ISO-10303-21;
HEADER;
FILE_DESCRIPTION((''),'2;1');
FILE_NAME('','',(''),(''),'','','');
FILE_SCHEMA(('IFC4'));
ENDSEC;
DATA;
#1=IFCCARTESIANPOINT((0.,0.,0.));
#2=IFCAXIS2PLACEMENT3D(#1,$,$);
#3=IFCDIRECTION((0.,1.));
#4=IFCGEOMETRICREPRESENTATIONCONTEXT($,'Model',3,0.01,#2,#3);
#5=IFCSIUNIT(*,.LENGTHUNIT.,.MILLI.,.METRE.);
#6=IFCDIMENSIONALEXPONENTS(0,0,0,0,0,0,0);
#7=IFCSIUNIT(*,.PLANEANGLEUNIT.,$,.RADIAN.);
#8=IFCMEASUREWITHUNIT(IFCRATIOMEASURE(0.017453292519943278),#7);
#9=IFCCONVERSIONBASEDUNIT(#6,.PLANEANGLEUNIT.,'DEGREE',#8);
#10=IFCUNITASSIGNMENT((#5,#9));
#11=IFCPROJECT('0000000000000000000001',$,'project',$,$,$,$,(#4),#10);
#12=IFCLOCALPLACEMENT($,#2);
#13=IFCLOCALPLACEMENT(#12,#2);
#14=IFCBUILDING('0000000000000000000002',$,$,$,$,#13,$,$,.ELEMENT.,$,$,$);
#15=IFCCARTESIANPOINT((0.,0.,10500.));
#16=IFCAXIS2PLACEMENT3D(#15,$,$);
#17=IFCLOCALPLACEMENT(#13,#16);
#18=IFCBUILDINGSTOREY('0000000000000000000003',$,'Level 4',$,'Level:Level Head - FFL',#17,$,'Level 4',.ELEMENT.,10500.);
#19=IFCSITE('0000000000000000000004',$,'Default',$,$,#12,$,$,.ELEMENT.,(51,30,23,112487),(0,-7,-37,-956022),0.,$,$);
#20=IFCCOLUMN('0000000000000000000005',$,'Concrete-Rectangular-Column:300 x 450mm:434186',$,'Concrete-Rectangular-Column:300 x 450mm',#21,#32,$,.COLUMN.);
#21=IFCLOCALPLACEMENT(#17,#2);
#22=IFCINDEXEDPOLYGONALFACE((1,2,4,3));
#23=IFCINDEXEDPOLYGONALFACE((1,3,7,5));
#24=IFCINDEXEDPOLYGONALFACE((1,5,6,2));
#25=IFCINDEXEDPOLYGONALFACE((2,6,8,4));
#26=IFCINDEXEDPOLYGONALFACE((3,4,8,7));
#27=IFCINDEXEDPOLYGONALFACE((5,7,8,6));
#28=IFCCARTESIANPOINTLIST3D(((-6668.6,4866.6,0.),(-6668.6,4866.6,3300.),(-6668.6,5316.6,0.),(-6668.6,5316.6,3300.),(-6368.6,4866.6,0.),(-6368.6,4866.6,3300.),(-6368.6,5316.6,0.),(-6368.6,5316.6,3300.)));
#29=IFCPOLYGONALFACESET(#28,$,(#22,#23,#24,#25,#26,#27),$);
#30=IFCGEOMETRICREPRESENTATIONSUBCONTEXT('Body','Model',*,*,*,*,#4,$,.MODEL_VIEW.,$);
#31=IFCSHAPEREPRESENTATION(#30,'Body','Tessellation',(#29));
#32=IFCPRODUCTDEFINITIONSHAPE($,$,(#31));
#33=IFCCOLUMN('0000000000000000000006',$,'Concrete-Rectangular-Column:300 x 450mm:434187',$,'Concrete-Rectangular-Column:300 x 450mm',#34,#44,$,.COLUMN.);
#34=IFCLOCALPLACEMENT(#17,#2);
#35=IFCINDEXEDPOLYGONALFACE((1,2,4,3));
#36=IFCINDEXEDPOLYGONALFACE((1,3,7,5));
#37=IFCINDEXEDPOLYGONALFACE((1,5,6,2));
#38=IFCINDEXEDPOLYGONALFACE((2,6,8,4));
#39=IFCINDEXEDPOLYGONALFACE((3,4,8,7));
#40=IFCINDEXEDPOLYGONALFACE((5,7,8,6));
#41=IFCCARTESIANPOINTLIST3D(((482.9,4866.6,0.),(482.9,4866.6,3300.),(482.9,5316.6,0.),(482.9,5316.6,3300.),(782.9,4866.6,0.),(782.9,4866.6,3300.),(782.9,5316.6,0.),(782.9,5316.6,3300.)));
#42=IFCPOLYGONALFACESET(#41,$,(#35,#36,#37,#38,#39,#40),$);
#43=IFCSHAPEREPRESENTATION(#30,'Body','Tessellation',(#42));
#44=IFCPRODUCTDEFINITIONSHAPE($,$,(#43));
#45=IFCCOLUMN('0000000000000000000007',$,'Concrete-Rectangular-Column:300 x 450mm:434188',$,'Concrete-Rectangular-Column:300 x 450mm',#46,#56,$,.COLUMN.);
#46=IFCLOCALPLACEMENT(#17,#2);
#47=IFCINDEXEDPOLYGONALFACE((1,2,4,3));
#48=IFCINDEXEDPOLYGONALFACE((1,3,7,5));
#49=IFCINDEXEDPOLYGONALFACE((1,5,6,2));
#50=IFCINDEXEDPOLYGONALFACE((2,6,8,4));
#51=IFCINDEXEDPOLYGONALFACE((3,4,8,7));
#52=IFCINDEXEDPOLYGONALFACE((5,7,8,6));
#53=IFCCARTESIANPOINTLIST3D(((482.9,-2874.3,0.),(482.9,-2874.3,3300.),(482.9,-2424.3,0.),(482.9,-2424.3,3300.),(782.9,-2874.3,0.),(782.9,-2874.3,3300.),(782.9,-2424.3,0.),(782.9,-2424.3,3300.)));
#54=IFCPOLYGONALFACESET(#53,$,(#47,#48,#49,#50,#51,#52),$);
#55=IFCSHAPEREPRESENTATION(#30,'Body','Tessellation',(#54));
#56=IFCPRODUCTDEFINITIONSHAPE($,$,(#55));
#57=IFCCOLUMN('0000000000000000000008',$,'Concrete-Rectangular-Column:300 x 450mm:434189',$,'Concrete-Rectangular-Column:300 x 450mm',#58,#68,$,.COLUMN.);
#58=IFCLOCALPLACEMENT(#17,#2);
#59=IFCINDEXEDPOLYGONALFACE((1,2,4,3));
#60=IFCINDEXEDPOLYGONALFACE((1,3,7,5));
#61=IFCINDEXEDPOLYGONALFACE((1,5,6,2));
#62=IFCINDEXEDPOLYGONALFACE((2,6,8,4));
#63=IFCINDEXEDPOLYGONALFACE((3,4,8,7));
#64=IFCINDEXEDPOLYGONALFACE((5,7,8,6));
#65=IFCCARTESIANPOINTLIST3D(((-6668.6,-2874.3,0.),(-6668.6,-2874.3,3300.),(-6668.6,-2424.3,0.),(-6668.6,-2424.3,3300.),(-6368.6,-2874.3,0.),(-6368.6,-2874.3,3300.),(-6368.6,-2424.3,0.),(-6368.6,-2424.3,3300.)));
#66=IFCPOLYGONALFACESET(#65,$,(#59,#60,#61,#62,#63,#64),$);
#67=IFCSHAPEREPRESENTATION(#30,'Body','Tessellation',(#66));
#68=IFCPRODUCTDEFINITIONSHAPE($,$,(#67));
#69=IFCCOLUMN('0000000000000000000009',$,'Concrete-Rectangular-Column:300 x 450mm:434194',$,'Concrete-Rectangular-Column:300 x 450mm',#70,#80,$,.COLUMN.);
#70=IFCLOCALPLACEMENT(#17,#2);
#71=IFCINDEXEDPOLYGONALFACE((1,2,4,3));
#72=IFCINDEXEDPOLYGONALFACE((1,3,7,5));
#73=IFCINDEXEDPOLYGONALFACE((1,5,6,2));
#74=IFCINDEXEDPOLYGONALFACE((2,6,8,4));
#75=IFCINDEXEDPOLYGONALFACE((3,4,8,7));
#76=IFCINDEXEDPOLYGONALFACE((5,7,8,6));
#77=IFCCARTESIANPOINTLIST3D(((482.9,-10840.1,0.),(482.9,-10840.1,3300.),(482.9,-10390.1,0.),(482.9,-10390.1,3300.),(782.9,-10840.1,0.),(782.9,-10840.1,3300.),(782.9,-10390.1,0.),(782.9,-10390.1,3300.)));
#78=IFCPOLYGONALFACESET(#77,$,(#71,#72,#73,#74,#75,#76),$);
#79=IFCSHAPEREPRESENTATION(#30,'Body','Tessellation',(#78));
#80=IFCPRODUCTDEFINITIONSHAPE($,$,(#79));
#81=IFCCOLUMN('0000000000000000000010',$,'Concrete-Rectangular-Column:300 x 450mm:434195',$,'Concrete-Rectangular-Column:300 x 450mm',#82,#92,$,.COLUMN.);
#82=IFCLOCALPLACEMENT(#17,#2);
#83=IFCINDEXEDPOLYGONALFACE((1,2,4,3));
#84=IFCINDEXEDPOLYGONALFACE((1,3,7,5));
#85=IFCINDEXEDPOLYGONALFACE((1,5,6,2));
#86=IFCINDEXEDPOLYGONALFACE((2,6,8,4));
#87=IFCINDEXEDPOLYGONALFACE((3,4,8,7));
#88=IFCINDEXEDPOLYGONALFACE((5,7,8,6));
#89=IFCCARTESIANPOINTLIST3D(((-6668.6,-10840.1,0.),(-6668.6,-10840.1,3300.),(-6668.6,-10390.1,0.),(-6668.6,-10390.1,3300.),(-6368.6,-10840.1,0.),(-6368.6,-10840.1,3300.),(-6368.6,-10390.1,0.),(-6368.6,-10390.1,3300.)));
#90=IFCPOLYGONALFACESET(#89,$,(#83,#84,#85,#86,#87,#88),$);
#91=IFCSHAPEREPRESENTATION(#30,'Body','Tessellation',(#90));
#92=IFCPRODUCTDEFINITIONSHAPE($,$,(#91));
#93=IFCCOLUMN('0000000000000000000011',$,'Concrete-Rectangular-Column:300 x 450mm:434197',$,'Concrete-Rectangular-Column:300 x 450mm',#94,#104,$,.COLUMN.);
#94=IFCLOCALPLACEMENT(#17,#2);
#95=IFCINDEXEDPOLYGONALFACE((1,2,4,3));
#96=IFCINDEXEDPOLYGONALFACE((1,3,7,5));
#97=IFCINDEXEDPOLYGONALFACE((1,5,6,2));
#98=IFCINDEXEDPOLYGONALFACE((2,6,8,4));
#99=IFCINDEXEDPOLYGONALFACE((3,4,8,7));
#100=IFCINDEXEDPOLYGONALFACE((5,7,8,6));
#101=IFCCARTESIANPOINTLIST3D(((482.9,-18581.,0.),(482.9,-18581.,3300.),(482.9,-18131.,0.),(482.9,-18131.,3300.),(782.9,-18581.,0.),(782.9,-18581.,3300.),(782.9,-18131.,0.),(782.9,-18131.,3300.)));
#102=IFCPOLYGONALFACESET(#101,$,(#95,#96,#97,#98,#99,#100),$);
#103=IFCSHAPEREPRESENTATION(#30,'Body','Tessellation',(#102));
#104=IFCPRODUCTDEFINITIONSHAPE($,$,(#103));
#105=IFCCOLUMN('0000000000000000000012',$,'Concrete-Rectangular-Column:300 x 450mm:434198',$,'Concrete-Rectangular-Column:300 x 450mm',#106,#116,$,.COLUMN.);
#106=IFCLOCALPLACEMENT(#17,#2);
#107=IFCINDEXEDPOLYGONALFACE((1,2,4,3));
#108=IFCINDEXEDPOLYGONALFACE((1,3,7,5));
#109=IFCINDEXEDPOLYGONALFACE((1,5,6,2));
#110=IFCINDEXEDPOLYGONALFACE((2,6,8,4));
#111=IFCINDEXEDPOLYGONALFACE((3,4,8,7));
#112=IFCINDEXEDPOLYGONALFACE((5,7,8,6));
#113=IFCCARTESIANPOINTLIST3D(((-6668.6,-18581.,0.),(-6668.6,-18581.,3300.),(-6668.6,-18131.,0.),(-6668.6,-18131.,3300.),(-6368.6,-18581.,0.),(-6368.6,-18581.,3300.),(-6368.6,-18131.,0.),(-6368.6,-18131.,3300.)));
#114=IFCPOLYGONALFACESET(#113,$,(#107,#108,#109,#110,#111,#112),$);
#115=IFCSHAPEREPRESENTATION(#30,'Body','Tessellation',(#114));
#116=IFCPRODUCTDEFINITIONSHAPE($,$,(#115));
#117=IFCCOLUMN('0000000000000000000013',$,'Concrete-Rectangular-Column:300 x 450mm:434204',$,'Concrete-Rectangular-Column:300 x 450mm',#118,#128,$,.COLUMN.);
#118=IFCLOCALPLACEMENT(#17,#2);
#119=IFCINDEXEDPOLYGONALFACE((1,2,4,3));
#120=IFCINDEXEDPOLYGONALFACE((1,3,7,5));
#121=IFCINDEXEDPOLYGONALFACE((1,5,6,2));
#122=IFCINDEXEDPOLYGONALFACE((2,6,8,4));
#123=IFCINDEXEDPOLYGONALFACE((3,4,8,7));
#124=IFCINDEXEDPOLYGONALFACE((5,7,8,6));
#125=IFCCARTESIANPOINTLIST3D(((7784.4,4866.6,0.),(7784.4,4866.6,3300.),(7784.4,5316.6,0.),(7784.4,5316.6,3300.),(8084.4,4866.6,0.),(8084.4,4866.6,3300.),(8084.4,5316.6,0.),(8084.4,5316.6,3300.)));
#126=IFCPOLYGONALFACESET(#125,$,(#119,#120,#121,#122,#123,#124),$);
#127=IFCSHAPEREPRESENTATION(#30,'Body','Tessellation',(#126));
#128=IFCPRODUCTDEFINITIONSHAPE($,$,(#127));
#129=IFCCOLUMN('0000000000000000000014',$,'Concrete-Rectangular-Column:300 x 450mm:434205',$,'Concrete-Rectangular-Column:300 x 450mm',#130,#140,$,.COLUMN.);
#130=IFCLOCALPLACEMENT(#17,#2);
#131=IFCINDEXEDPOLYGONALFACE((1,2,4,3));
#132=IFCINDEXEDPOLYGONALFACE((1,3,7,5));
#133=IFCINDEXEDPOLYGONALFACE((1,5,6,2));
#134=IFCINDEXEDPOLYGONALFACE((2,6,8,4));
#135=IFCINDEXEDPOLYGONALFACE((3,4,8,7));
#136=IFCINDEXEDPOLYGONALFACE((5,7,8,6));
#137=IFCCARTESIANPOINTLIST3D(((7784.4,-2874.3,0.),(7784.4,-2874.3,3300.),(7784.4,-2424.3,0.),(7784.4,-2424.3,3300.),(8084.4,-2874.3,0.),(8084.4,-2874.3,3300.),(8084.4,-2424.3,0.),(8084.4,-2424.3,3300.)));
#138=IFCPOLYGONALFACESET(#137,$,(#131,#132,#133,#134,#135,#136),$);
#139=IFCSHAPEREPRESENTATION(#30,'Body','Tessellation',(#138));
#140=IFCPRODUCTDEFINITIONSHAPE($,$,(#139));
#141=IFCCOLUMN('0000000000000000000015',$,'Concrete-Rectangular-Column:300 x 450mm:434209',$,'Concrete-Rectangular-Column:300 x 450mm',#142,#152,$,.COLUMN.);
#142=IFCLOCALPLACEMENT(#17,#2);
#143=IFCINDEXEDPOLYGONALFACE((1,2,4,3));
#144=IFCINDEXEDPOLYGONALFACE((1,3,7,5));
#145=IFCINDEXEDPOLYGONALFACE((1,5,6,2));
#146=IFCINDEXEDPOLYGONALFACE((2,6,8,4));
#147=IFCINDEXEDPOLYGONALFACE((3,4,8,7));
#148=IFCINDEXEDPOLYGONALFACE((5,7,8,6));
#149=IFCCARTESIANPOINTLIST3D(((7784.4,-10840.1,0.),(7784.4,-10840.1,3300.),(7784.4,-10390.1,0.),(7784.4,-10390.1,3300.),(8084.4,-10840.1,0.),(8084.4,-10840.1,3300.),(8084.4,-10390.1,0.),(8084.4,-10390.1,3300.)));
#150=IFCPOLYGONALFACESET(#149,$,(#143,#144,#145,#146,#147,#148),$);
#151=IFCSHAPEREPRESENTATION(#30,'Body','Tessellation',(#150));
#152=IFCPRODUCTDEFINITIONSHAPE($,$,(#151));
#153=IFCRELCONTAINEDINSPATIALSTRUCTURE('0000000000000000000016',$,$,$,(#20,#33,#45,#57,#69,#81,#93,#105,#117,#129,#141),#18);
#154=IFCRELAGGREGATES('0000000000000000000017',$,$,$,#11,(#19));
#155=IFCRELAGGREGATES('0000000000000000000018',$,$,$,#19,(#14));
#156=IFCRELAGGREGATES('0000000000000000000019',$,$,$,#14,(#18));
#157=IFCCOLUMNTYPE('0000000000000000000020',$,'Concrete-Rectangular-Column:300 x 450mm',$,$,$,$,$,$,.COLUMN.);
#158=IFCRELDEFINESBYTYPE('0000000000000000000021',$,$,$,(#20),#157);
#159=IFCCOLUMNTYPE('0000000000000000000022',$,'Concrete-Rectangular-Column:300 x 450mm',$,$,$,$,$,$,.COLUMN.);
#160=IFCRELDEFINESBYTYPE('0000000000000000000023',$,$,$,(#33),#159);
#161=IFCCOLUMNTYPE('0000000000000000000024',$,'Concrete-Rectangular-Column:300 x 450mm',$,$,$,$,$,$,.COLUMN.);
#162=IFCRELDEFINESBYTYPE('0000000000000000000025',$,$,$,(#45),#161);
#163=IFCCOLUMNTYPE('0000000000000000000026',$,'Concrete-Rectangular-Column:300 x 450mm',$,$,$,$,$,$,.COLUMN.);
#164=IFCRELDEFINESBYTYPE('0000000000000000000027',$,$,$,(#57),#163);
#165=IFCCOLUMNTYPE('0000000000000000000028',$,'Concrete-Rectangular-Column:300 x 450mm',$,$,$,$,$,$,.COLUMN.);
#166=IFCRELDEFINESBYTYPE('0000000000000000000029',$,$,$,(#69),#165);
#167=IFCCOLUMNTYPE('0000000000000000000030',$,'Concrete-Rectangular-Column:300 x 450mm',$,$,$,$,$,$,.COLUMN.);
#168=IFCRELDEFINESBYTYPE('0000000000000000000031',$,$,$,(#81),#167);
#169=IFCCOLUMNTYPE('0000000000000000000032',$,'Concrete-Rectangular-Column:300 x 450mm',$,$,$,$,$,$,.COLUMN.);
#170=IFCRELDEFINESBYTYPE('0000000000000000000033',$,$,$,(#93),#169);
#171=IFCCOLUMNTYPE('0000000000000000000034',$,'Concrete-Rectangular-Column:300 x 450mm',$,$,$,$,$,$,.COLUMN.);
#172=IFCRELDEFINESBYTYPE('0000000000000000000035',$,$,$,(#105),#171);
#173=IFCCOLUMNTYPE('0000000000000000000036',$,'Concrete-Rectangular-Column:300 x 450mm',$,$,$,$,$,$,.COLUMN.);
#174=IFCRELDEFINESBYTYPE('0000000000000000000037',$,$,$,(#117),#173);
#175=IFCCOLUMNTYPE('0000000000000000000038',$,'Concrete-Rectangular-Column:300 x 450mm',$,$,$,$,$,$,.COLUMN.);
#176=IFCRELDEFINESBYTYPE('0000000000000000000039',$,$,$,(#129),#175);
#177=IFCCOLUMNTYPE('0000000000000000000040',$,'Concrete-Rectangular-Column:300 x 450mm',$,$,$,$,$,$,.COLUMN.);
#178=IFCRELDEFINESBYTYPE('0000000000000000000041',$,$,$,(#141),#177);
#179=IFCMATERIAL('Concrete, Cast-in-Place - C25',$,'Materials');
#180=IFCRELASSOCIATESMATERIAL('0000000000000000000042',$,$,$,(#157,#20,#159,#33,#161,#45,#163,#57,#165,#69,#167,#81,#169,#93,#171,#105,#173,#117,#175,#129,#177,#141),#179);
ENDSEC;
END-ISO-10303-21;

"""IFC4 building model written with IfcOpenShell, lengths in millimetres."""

from ifc_helpers import new_model, entity, si_unit, converted_unit, direction, frame, origin, place, context, subcontext, project, spatial, indexed_curve, outline, extrude, source, transform, mapped, material, type_object, type_shapes, element, save


model = new_model("IFC4")

# Units and contexts
model_context = context("Model", 3, precision=0.01, world=origin(), true_north=direction((0.0, 1.0)))
body_context = subcontext(model_context, "Body", "Model", "MODEL_VIEW")
ifc_project = project(units=[si_unit("LENGTHUNIT", "METRE", prefix="MILLI"), converted_unit("PLANEANGLEUNIT", "DEGREE", entity("IfcRatioMeasure", 0.017453292519943278), si_unit("PLANEANGLEUNIT", "RADIAN"), dimensions=[0, 0, 0, 0, 0, 0, 0])], contexts=[model_context])

# Site, building, storey
site_placement = place(None, origin())
site = spatial("IfcSite", under=ifc_project, at=site_placement, Name="Default", CompositionType="ELEMENT", RefLatitude=(51, 30, 23, 112487), RefLongitude=(0, -7, -37, -956022), RefElevation=0.0)
building_placement = place(site_placement, origin())
building = spatial("IfcBuilding", under=site, at=building_placement, CompositionType="ELEMENT")
storey_placement = place(building_placement, frame((0.0, 0.0, 10500.0)))
storey = spatial("IfcBuildingStorey", under=building, at=storey_placement, Name="Level 4", ObjectType="Level:Level Head - FFL", LongName="Level 4", CompositionType="ELEMENT", Elevation=10500.0)

# Columns
ifc_material = material(Name="Concrete, Cast-in-Place - C25", Category="Materials")
column_type_1 = type_object("IfcColumnType", Name="Concrete-Rectangular-Column:300 x 450mm", PredefinedType="COLUMN", material=ifc_material)
shared_shape_1 = source(origin(), body_context, "Body", "SweptSolid", [
    extrude(outline(indexed_curve([(-225.0, -150.0), (225.0, -150.0), (225.0, 150.0), (-225.0, 150.0), (-225.0, -150.0)], self_intersect=False)), frame((-6518.6, 5091.6, 10500.0), z_axis=(0.0, 0.0, 1.0), x_axis=(0.0, -1.0, 0.0)), (0.0, 0.0, 1.0), 3300.0),
])
type_shapes(column_type_1, [shared_shape_1])
column_1_placement = place(storey_placement, frame((0.0, 0.0, -10500.0)))
element("IfcColumn", 1, at=column_1_placement, inside=storey, type_object=column_type_1, material=ifc_material, Name="Concrete-Rectangular-Column:300 x 450mm:434186", ObjectType="Concrete-Rectangular-Column:300 x 450mm", PredefinedType="COLUMN", context=body_context, shape_type="MappedRepresentation", body=[
    mapped(shared_shape_1, transform((0.0, 0.0, 0.0), scale=1.0)),
])
column_type_2 = type_object("IfcColumnType", Name="Concrete-Rectangular-Column:300 x 450mm", PredefinedType="COLUMN", material=ifc_material)
shared_shape_2 = source(origin(), body_context, "Body", "SweptSolid", [
    extrude(outline(indexed_curve([(-225.0, -150.0), (225.0, -150.0), (225.0, 150.0), (-225.0, 150.0), (-225.0, -150.0)], self_intersect=False)), frame((632.9, 5091.6, 10500.0), z_axis=(0.0, 0.0, 1.0), x_axis=(0.0, -1.0, 0.0)), (0.0, 0.0, 1.0), 3300.0),
])
type_shapes(column_type_2, [shared_shape_2])
column_2_placement = place(storey_placement, frame((0.0, 0.0, -10500.0)))
element("IfcColumn", 2, at=column_2_placement, inside=storey, type_object=column_type_2, material=ifc_material, Name="Concrete-Rectangular-Column:300 x 450mm:434187", ObjectType="Concrete-Rectangular-Column:300 x 450mm", PredefinedType="COLUMN", context=body_context, shape_type="MappedRepresentation", body=[
    mapped(shared_shape_2, transform((0.0, 0.0, 0.0), scale=1.0)),
])
column_type_3 = type_object("IfcColumnType", Name="Concrete-Rectangular-Column:300 x 450mm", PredefinedType="COLUMN", material=ifc_material)
shared_shape_3 = source(origin(), body_context, "Body", "SweptSolid", [
    extrude(outline(indexed_curve([(-225.0, -150.0), (225.0, -150.0), (225.0, 150.0), (-225.0, 150.0), (-225.0, -150.0)], self_intersect=False)), frame((632.9, -2649.3, 10500.0), z_axis=(0.0, 0.0, 1.0), x_axis=(0.0, -1.0, 0.0)), (0.0, 0.0, 1.0), 3300.0),
])
type_shapes(column_type_3, [shared_shape_3])
column_3_placement = place(storey_placement, frame((0.0, 0.0, -10500.0)))
element("IfcColumn", 3, at=column_3_placement, inside=storey, type_object=column_type_3, material=ifc_material, Name="Concrete-Rectangular-Column:300 x 450mm:434188", ObjectType="Concrete-Rectangular-Column:300 x 450mm", PredefinedType="COLUMN", context=body_context, shape_type="MappedRepresentation", body=[
    mapped(shared_shape_3, transform((0.0, 0.0, 0.0), scale=1.0)),
])
column_type_4 = type_object("IfcColumnType", Name="Concrete-Rectangular-Column:300 x 450mm", PredefinedType="COLUMN", material=ifc_material)
shared_shape_4 = source(origin(), body_context, "Body", "SweptSolid", [
    extrude(outline(indexed_curve([(-225.0, -150.0), (225.0, -150.0), (225.0, 150.0), (-225.0, 150.0), (-225.0, -150.0)], self_intersect=False)), frame((-6518.6, -2649.3, 10500.0), z_axis=(0.0, 0.0, 1.0), x_axis=(0.0, -1.0, 0.0)), (0.0, 0.0, 1.0), 3300.0),
])
type_shapes(column_type_4, [shared_shape_4])
column_4_placement = place(storey_placement, frame((0.0, 0.0, -10500.0)))
element("IfcColumn", 4, at=column_4_placement, inside=storey, type_object=column_type_4, material=ifc_material, Name="Concrete-Rectangular-Column:300 x 450mm:434189", ObjectType="Concrete-Rectangular-Column:300 x 450mm", PredefinedType="COLUMN", context=body_context, shape_type="MappedRepresentation", body=[
    mapped(shared_shape_4, transform((0.0, 0.0, 0.0), scale=1.0)),
])
column_type_5 = type_object("IfcColumnType", Name="Concrete-Rectangular-Column:300 x 450mm", PredefinedType="COLUMN", material=ifc_material)
shared_shape_5 = source(origin(), body_context, "Body", "SweptSolid", [
    extrude(outline(indexed_curve([(-225.0, -150.0), (225.0, -150.0), (225.0, 150.0), (-225.0, 150.0), (-225.0, -150.0)], self_intersect=False)), frame((632.9, -10615.1, 10500.0), z_axis=(0.0, 0.0, 1.0), x_axis=(0.0, -1.0, 0.0)), (0.0, 0.0, 1.0), 3300.0),
])
type_shapes(column_type_5, [shared_shape_5])
column_5_placement = place(storey_placement, frame((0.0, 0.0, -10500.0)))
element("IfcColumn", 5, at=column_5_placement, inside=storey, type_object=column_type_5, material=ifc_material, Name="Concrete-Rectangular-Column:300 x 450mm:434194", ObjectType="Concrete-Rectangular-Column:300 x 450mm", PredefinedType="COLUMN", context=body_context, shape_type="MappedRepresentation", body=[
    mapped(shared_shape_5, transform((0.0, 0.0, 0.0), scale=1.0)),
])
column_type_6 = type_object("IfcColumnType", Name="Concrete-Rectangular-Column:300 x 450mm", PredefinedType="COLUMN", material=ifc_material)
shared_shape_6 = source(origin(), body_context, "Body", "SweptSolid", [
    extrude(outline(indexed_curve([(-225.0, -150.0), (225.0, -150.0), (225.0, 150.0), (-225.0, 150.0), (-225.0, -150.0)], self_intersect=False)), frame((-6518.6, -10615.1, 10500.0), z_axis=(0.0, 0.0, 1.0), x_axis=(0.0, -1.0, 0.0)), (0.0, 0.0, 1.0), 3300.0),
])
type_shapes(column_type_6, [shared_shape_6])
column_6_placement = place(storey_placement, frame((0.0, 0.0, -10500.0)))
element("IfcColumn", 6, at=column_6_placement, inside=storey, type_object=column_type_6, material=ifc_material, Name="Concrete-Rectangular-Column:300 x 450mm:434195", ObjectType="Concrete-Rectangular-Column:300 x 450mm", PredefinedType="COLUMN", context=body_context, shape_type="MappedRepresentation", body=[
    mapped(shared_shape_6, transform((0.0, 0.0, 0.0), scale=1.0)),
])
column_type_7 = type_object("IfcColumnType", Name="Concrete-Rectangular-Column:300 x 450mm", PredefinedType="COLUMN", material=ifc_material)
shared_shape_7 = source(origin(), body_context, "Body", "SweptSolid", [
    extrude(outline(indexed_curve([(-225.0, -150.0), (225.0, -150.0), (225.0, 150.0), (-225.0, 150.0), (-225.0, -150.0)], self_intersect=False)), frame((632.9, -18356.0, 10500.0), z_axis=(0.0, 0.0, 1.0), x_axis=(0.0, -1.0, 0.0)), (0.0, 0.0, 1.0), 3300.0),
])
type_shapes(column_type_7, [shared_shape_7])
column_7_placement = place(storey_placement, frame((0.0, 0.0, -10500.0)))
element("IfcColumn", 7, at=column_7_placement, inside=storey, type_object=column_type_7, material=ifc_material, Name="Concrete-Rectangular-Column:300 x 450mm:434197", ObjectType="Concrete-Rectangular-Column:300 x 450mm", PredefinedType="COLUMN", context=body_context, shape_type="MappedRepresentation", body=[
    mapped(shared_shape_7, transform((0.0, 0.0, 0.0), scale=1.0)),
])
column_type_8 = type_object("IfcColumnType", Name="Concrete-Rectangular-Column:300 x 450mm", PredefinedType="COLUMN", material=ifc_material)
shared_shape_8 = source(origin(), body_context, "Body", "SweptSolid", [
    extrude(outline(indexed_curve([(-225.0, -150.0), (225.0, -150.0), (225.0, 150.0), (-225.0, 150.0), (-225.0, -150.0)], self_intersect=False)), frame((-6518.6, -18356.0, 10500.0), z_axis=(0.0, 0.0, 1.0), x_axis=(0.0, -1.0, 0.0)), (0.0, 0.0, 1.0), 3300.0),
])
type_shapes(column_type_8, [shared_shape_8])
column_8_placement = place(storey_placement, frame((0.0, 0.0, -10500.0)))
element("IfcColumn", 8, at=column_8_placement, inside=storey, type_object=column_type_8, material=ifc_material, Name="Concrete-Rectangular-Column:300 x 450mm:434198", ObjectType="Concrete-Rectangular-Column:300 x 450mm", PredefinedType="COLUMN", context=body_context, shape_type="MappedRepresentation", body=[
    mapped(shared_shape_8, transform((0.0, 0.0, 0.0), scale=1.0)),
])
column_type_9 = type_object("IfcColumnType", Name="Concrete-Rectangular-Column:300 x 450mm", PredefinedType="COLUMN", material=ifc_material)
shared_shape_9 = source(origin(), body_context, "Body", "SweptSolid", [
    extrude(outline(indexed_curve([(-225.0, -150.0), (225.0, -150.0), (225.0, 150.0), (-225.0, 150.0), (-225.0, -150.0)], self_intersect=False)), frame((7934.4, 5091.6, 10500.0), z_axis=(0.0, 0.0, 1.0), x_axis=(0.0, -1.0, 0.0)), (0.0, 0.0, 1.0), 3300.0),
])
type_shapes(column_type_9, [shared_shape_9])
column_9_placement = place(storey_placement, frame((0.0, 0.0, -10500.0)))
element("IfcColumn", 9, at=column_9_placement, inside=storey, type_object=column_type_9, material=ifc_material, Name="Concrete-Rectangular-Column:300 x 450mm:434204", ObjectType="Concrete-Rectangular-Column:300 x 450mm", PredefinedType="COLUMN", context=body_context, shape_type="MappedRepresentation", body=[
    mapped(shared_shape_9, transform((0.0, 0.0, 0.0), scale=1.0)),
])
column_type_10 = type_object("IfcColumnType", Name="Concrete-Rectangular-Column:300 x 450mm", PredefinedType="COLUMN", material=ifc_material)
shared_shape_10 = source(origin(), body_context, "Body", "SweptSolid", [
    extrude(outline(indexed_curve([(-225.0, -150.0), (225.0, -150.0), (225.0, 150.0), (-225.0, 150.0), (-225.0, -150.0)], self_intersect=False)), frame((7934.4, -2649.3, 10500.0), z_axis=(0.0, 0.0, 1.0), x_axis=(0.0, -1.0, 0.0)), (0.0, 0.0, 1.0), 3300.0),
])
type_shapes(column_type_10, [shared_shape_10])
column_10_placement = place(storey_placement, frame((0.0, 0.0, -10500.0)))
element("IfcColumn", 10, at=column_10_placement, inside=storey, type_object=column_type_10, material=ifc_material, Name="Concrete-Rectangular-Column:300 x 450mm:434205", ObjectType="Concrete-Rectangular-Column:300 x 450mm", PredefinedType="COLUMN", context=body_context, shape_type="MappedRepresentation", body=[
    mapped(shared_shape_10, transform((0.0, 0.0, 0.0), scale=1.0)),
])
column_type_11 = type_object("IfcColumnType", Name="Concrete-Rectangular-Column:300 x 450mm", PredefinedType="COLUMN", material=ifc_material)
shared_shape_11 = source(origin(), body_context, "Body", "SweptSolid", [
    extrude(outline(indexed_curve([(-225.0, -150.0), (225.0, -150.0), (225.0, 150.0), (-225.0, 150.0), (-225.0, -150.0)], self_intersect=False)), frame((7934.4, -10615.1, 10500.0), z_axis=(0.0, 0.0, 1.0), x_axis=(0.0, -1.0, 0.0)), (0.0, 0.0, 1.0), 3300.0),
])
type_shapes(column_type_11, [shared_shape_11])
column_11_placement = place(storey_placement, frame((0.0, 0.0, -10500.0)))
element("IfcColumn", 11, at=column_11_placement, inside=storey, type_object=column_type_11, material=ifc_material, Name="Concrete-Rectangular-Column:300 x 450mm:434209", ObjectType="Concrete-Rectangular-Column:300 x 450mm", PredefinedType="COLUMN", context=body_context, shape_type="MappedRepresentation", body=[
    mapped(shared_shape_11, transform((0.0, 0.0, 0.0), scale=1.0)),
])

save(model, "model.ifc")
